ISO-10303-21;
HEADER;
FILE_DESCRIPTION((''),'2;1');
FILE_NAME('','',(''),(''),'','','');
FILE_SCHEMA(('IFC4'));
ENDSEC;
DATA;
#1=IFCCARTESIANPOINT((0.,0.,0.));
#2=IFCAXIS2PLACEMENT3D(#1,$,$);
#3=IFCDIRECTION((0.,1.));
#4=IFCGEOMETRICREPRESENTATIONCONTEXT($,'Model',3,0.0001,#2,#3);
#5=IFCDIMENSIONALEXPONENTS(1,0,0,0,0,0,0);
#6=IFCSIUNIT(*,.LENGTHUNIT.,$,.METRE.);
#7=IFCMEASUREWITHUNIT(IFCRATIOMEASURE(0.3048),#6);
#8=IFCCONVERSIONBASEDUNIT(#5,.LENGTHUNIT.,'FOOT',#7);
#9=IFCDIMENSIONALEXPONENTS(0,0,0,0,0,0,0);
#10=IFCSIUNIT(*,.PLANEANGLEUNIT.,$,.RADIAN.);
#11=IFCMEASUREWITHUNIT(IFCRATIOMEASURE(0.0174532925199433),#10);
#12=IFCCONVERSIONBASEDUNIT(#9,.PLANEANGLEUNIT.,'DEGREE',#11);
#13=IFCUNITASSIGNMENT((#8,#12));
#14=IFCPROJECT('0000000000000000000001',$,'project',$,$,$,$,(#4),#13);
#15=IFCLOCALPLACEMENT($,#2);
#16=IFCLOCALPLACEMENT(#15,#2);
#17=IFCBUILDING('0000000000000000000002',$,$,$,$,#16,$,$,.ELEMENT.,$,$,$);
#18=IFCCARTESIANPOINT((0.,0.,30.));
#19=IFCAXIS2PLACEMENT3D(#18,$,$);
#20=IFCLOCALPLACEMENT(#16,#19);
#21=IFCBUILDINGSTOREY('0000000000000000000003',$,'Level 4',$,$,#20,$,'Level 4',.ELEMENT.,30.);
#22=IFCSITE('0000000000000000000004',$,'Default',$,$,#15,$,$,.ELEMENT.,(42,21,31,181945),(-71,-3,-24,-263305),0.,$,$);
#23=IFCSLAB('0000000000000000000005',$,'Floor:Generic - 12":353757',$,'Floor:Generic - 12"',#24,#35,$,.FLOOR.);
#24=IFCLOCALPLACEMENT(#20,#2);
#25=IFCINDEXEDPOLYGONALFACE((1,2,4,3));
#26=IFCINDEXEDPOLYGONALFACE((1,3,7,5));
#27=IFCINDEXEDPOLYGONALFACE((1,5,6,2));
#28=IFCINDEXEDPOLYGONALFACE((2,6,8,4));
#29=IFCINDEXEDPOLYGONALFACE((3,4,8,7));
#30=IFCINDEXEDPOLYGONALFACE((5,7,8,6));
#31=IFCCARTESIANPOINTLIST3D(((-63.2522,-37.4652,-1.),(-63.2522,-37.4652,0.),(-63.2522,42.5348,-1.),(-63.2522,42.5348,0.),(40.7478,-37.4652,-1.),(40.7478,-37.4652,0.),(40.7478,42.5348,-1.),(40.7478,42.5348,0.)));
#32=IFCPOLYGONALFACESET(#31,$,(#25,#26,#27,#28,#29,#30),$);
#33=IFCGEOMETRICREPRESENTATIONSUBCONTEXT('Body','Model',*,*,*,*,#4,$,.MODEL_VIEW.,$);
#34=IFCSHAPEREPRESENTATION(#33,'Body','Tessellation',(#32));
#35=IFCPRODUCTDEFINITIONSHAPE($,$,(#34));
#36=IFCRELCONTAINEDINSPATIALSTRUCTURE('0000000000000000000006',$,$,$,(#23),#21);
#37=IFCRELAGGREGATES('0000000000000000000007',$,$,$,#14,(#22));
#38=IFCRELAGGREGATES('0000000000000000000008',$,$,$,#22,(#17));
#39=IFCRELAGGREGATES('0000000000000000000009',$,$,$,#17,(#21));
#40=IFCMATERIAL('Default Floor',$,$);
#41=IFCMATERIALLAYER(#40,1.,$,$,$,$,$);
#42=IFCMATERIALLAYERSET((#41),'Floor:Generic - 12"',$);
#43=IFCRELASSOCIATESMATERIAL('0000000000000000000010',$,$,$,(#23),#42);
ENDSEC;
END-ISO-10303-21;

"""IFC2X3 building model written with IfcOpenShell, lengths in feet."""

from ifc_helpers import new_model, entity, si_unit, converted_unit, direction, frame, origin, origin_2d_with_axis, place, context, subcontext, project, spatial, rectangle, extrude, material, layer, layer_set, layer_usage, element, save


model = new_model("IFC2X3")

# Units and contexts
model_context = context("Model", 3, precision=0.0001, world=origin(), true_north=direction((0.0, 1.0)))
body_context = subcontext(model_context, "Body", "Model", "MODEL_VIEW")
ifc_project = project(units=[converted_unit("LENGTHUNIT", "FOOT", entity("IfcRatioMeasure", 0.3048), si_unit("LENGTHUNIT", "METRE"), dimensions=[1, 0, 0, 0, 0, 0, 0]), converted_unit("PLANEANGLEUNIT", "DEGREE", entity("IfcRatioMeasure", 0.0174532925199433), si_unit("PLANEANGLEUNIT", "RADIAN"), dimensions=[0, 0, 0, 0, 0, 0, 0])], contexts=[model_context])

# Site, building, storey
site_placement = place(None, origin())
site = spatial("IfcSite", under=ifc_project, at=site_placement, Name="Default", CompositionType="ELEMENT", RefLatitude=(42, 21, 31, 181945), RefLongitude=(-71, -3, -24, -263305), RefElevation=0.0)
building_placement = place(site_placement, origin())
building = spatial("IfcBuilding", under=site, at=building_placement, CompositionType="ELEMENT")
storey_placement = place(building_placement, frame((0.0, 0.0, 30.0)))
storey = spatial("IfcBuildingStorey", under=building, at=storey_placement, Name="Level 4", LongName="Level 4", CompositionType="ELEMENT", Elevation=30.0)

# Slab
ifc_material = material(Name="Default Floor")
ifc_layer = layer(ifc_material, 1.0)
ifc_layer_set = layer_set([ifc_layer], Name="Floor:Generic - 12\"")
ifc_layer_usage = layer_usage(ifc_layer_set, "AXIS3", "POSITIVE", 0.0)
slab_placement = place(storey_placement, origin())
element("IfcSlab", 1, at=slab_placement, inside=storey, material=ifc_layer_usage, Name="Floor:Generic - 12\":353757", ObjectType="Floor:Generic - 12\"", PredefinedType="FLOOR", context=body_context, shape_type="SweptSolid", body=[
    extrude(rectangle(XDim=80.0, YDim=104.0, at=origin_2d_with_axis()), frame((-11.2522, 2.5348, 0.0), z_axis=(0.0, 0.0, -1.0), x_axis=(0.0, 1.0, 0.0)), (0.0, 0.0, 1.0), 1.0),
])

save(model, "model.ifc")
